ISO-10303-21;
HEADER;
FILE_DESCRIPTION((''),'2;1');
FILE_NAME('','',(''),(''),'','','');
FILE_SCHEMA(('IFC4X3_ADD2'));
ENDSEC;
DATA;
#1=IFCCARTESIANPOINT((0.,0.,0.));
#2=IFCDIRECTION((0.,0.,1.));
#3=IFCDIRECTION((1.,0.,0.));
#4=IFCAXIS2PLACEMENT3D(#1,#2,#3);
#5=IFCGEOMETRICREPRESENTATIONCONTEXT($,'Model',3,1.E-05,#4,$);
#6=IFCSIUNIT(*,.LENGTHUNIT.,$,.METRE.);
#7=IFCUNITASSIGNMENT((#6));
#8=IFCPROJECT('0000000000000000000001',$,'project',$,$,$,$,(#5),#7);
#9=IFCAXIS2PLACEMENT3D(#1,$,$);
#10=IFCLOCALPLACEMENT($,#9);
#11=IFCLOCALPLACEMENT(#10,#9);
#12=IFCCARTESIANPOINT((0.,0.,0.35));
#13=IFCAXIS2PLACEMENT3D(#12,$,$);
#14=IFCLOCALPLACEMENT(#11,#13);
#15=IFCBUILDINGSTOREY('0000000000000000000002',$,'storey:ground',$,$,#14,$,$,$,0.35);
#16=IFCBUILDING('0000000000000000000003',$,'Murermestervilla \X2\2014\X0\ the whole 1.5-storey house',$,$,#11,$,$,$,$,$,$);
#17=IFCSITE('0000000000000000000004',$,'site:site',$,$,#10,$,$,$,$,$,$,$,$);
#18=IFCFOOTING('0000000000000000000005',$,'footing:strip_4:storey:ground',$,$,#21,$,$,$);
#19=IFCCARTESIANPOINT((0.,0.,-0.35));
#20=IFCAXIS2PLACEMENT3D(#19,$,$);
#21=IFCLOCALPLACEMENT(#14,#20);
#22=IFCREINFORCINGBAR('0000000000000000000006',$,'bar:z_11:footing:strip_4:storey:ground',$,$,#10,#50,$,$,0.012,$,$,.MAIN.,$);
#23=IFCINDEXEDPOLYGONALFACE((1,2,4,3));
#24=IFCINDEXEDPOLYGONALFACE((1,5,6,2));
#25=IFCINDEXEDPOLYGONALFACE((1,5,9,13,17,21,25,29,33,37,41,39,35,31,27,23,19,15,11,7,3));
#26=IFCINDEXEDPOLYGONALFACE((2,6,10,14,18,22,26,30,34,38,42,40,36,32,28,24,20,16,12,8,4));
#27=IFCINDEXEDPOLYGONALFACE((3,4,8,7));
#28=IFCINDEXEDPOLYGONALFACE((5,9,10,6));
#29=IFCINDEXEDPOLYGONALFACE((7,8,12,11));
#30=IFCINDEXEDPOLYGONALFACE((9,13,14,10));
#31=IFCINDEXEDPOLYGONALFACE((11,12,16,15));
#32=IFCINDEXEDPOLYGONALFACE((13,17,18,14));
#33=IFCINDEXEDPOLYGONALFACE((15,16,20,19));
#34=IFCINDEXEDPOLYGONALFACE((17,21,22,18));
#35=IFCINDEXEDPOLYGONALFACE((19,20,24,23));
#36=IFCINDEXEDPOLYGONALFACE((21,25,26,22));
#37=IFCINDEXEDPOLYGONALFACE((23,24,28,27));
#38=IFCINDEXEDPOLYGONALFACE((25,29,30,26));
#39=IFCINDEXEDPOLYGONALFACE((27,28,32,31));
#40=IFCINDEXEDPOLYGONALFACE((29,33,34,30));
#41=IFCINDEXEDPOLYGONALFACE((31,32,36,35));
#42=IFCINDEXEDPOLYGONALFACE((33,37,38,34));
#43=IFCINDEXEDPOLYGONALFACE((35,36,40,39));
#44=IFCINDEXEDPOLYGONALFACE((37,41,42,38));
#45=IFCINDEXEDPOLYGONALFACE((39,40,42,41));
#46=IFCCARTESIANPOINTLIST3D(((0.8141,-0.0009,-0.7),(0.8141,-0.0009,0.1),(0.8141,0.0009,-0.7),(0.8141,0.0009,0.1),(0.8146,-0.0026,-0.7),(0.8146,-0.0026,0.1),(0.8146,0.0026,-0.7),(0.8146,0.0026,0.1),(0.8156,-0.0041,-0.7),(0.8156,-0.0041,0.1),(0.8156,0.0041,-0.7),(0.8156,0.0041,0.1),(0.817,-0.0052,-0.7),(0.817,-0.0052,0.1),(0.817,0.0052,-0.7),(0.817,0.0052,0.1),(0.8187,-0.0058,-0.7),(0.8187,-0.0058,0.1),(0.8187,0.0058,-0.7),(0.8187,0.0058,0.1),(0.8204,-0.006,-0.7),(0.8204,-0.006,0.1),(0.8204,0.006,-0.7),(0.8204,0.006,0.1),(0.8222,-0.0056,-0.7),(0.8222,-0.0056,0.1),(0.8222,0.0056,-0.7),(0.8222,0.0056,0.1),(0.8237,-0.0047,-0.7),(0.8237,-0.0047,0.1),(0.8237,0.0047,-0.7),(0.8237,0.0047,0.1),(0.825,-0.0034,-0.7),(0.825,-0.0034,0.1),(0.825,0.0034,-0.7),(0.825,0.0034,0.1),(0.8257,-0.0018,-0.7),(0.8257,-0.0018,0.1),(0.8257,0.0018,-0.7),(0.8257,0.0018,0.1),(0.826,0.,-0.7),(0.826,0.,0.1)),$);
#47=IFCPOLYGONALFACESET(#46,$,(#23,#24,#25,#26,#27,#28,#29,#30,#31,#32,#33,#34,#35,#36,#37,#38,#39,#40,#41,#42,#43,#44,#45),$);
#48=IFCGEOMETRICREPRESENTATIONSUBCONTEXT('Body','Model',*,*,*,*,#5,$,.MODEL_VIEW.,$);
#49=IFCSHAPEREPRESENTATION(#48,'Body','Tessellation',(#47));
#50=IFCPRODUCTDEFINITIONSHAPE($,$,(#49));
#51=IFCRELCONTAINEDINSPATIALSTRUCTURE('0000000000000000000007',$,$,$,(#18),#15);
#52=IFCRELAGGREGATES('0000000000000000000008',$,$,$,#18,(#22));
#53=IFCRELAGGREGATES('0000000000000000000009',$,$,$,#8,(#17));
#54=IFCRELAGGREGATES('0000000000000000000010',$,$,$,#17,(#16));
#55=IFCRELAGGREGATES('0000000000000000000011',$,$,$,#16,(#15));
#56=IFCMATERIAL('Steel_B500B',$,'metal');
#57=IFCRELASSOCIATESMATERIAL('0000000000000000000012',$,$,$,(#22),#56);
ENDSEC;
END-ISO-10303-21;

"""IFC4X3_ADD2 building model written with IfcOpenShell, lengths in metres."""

from ifc_helpers import new_model, entity, si_unit, frame, origin, origin_with_axes, place, context, subcontext, project, spatial, material, element, aggregate, save


model = new_model("IFC4X3_ADD2")

# Units and contexts
model_context = context("Model", 3, precision=1e-05, world=origin_with_axes())
body_context = subcontext(model_context, "Body", "Model", "MODEL_VIEW")
ifc_project = project(units=[si_unit("LENGTHUNIT", "METRE")], contexts=[model_context])

# Site, building, storey
placement_1 = place(None, origin())
site = spatial("IfcSite", under=ifc_project, at=placement_1, Name="site:site")
building_placement = place(placement_1, origin())
building = spatial("IfcBuilding", under=site, at=building_placement, Name="Murermestervilla — the whole 1.5-storey house")
storey_placement = place(building_placement, frame((0.0, 0.0, 0.35)))
storey = spatial("IfcBuildingStorey", under=building, at=storey_placement, Name="storey:ground", Elevation=0.35)

# Footing, reinforcing bar
placement_2 = place(storey_placement, frame((0.0, 0.0, -0.35)))
ifc_material = material(Name="Steel_B500B", Category="metal")
footing_1 = element("IfcFooting", 1, at=placement_2, inside=storey, Name="footing:strip_4:storey:ground")
reinforcing_bar_1 = element("IfcReinforcingBar", 2, at=placement_1, material=ifc_material, Name="bar:z_11:footing:strip_4:storey:ground", NominalDiameter=0.012, PredefinedType="MAIN", context=body_context, shape_type="AdvancedSweptSolid", body=[
    entity("IfcSweptDiskSolid", entity("IfcPolyline", [entity("IfcCartesianPoint", [0.82, 0.0, -0.7]), entity("IfcCartesianPoint", [0.82, 0.0, 0.1])]), 0.006),
])
aggregate(footing_1, [reinforcing_bar_1])

save(model, "model.ifc")
